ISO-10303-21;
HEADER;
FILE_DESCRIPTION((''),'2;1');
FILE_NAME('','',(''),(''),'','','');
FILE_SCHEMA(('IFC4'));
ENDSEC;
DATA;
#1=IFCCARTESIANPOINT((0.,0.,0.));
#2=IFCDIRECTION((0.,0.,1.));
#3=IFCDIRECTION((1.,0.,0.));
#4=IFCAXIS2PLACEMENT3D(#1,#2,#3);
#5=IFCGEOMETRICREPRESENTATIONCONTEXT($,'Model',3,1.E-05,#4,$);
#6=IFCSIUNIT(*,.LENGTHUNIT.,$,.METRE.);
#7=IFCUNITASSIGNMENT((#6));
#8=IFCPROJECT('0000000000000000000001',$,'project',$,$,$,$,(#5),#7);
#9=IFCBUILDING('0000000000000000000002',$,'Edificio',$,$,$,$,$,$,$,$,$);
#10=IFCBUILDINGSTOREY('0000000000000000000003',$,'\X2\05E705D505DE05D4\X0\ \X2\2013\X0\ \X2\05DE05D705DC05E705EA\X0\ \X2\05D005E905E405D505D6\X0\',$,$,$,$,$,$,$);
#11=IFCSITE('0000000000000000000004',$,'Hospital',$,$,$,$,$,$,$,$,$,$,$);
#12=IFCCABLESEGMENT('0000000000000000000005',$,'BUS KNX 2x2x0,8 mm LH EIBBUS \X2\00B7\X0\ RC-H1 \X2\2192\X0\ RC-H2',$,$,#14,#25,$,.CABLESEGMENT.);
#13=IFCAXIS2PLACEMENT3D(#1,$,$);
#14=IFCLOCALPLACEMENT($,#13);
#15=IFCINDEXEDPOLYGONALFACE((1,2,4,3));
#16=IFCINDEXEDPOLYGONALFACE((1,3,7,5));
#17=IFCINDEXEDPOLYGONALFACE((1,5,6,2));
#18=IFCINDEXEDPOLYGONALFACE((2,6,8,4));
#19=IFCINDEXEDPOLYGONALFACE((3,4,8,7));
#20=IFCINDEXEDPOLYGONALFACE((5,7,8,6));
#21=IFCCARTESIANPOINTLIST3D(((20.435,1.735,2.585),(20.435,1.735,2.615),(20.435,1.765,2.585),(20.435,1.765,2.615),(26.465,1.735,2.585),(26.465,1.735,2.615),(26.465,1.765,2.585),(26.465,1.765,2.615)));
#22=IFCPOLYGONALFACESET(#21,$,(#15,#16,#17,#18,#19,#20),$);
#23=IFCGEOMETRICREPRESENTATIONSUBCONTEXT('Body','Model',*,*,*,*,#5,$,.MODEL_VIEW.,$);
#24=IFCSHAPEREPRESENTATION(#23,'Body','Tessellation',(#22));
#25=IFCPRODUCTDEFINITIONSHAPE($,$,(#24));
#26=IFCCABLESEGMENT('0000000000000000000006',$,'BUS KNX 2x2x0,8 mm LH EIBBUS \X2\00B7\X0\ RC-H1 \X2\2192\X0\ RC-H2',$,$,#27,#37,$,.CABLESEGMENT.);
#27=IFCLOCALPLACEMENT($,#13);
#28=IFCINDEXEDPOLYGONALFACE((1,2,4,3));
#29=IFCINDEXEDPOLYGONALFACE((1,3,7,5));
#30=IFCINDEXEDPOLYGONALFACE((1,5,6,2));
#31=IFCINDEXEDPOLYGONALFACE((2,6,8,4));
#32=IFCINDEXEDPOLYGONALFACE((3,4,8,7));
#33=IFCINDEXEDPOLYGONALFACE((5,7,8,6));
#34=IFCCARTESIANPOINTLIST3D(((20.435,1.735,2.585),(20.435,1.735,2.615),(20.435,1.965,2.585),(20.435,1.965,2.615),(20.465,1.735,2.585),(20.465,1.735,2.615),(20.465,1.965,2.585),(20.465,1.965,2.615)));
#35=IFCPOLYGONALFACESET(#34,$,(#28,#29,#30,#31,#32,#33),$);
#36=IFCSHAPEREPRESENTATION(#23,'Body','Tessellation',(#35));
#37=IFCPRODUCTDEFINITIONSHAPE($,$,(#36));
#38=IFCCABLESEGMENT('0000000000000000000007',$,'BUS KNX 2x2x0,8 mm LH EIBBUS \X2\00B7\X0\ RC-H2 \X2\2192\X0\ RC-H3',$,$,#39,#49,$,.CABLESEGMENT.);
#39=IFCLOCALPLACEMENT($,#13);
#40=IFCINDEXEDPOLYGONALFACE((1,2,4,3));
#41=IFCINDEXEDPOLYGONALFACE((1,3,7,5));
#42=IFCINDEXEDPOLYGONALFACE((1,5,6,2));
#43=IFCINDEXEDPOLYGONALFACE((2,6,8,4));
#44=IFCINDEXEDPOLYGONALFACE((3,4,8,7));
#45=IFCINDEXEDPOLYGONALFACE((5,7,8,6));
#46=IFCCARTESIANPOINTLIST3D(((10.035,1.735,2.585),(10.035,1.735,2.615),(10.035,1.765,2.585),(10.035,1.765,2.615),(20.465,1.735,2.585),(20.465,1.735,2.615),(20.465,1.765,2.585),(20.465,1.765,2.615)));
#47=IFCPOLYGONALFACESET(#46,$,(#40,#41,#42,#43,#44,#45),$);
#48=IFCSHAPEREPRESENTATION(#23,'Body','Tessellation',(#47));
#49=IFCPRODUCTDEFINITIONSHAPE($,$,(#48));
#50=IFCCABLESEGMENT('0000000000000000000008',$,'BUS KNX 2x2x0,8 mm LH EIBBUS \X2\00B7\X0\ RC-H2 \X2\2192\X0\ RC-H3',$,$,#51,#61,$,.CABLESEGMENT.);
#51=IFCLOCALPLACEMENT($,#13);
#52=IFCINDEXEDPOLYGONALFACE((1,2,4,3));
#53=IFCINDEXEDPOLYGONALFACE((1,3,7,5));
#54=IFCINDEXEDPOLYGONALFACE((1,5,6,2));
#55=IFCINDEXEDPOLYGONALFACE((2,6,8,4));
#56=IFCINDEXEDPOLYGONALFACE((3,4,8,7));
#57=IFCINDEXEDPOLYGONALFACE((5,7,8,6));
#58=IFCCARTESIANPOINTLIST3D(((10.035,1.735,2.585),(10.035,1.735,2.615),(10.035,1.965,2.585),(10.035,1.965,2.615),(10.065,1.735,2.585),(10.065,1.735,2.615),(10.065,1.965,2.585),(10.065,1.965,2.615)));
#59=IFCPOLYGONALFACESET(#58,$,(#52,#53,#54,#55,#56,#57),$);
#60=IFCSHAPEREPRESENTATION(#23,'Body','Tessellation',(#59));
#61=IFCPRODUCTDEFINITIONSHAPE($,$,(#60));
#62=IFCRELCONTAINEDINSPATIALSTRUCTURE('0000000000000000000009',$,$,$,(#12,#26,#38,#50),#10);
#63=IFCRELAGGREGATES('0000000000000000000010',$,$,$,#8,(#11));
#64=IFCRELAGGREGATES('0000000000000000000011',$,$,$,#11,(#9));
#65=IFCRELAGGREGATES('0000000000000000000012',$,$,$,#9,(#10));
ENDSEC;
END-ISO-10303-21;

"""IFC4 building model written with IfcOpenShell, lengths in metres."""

from ifc_helpers import new_model, si_unit, frame, origin_with_axes, context, subcontext, project, spatial, line, indexed_curve, outline, extrude, element, save


model = new_model("IFC4")

# Units and contexts
model_context = context("Model", 3, precision=1e-05, world=origin_with_axes())
body_context = subcontext(model_context, "Body", "Model", "MODEL_VIEW")
ifc_project = project(units=[si_unit("LENGTHUNIT", "METRE")], contexts=[model_context])

# Site, building, storey
site = spatial("IfcSite", under=ifc_project, Name="Hospital")
building = spatial("IfcBuilding", under=site, Name="Edificio")
storey = spatial("IfcBuildingStorey", under=building, Name="קומה – מחלקת אשפוז")

# Cable segments
element("IfcCableSegment", 1, inside=storey, Name="BUS KNX 2x2x0,8 mm LH EIBBUS · RC-H1 → RC-H2", PredefinedType="CABLESEGMENT", context=body_context, shape_type="SweptSolid", body=[
    extrude(outline(indexed_curve([(0.0, 0.0), (6.03, 0.0), (6.03, 0.03), (0.0, 0.03)], segments=[line(1, 2, 3, 4, 1)])), frame((20.435, 1.735, 2.585), z_axis=(0.0, 0.0, 1.0), x_axis=(1.0, 0.0, 0.0)), (0.0, 0.0, 1.0), 0.03),
])
element("IfcCableSegment", 2, inside=storey, Name="BUS KNX 2x2x0,8 mm LH EIBBUS · RC-H1 → RC-H2", PredefinedType="CABLESEGMENT", context=body_context, shape_type="SweptSolid", body=[
    extrude(outline(indexed_curve([(0.0, 0.0), (0.03, 0.0), (0.03, 0.23), (0.0, 0.23)], segments=[line(1, 2, 3, 4, 1)])), frame((20.435, 1.735, 2.585), z_axis=(0.0, 0.0, 1.0), x_axis=(1.0, 0.0, 0.0)), (0.0, 0.0, 1.0), 0.03),
])
element("IfcCableSegment", 3, inside=storey, Name="BUS KNX 2x2x0,8 mm LH EIBBUS · RC-H2 → RC-H3", PredefinedType="CABLESEGMENT", context=body_context, shape_type="SweptSolid", body=[
    extrude(outline(indexed_curve([(0.0, 0.0), (10.43, 0.0), (10.43, 0.03), (0.0, 0.03)], segments=[line(1, 2, 3, 4, 1)])), frame((10.035, 1.735, 2.585), z_axis=(0.0, 0.0, 1.0), x_axis=(1.0, 0.0, 0.0)), (0.0, 0.0, 1.0), 0.03),
])
element("IfcCableSegment", 4, inside=storey, Name="BUS KNX 2x2x0,8 mm LH EIBBUS · RC-H2 → RC-H3", PredefinedType="CABLESEGMENT", context=body_context, shape_type="SweptSolid", body=[
    extrude(outline(indexed_curve([(0.0, 0.0), (0.03, 0.0), (0.03, 0.23), (0.0, 0.23)], segments=[line(1, 2, 3, 4, 1)])), frame((10.035, 1.735, 2.585), z_axis=(0.0, 0.0, 1.0), x_axis=(1.0, 0.0, 0.0)), (0.0, 0.0, 1.0), 0.03),
])

save(model, "model.ifc")
